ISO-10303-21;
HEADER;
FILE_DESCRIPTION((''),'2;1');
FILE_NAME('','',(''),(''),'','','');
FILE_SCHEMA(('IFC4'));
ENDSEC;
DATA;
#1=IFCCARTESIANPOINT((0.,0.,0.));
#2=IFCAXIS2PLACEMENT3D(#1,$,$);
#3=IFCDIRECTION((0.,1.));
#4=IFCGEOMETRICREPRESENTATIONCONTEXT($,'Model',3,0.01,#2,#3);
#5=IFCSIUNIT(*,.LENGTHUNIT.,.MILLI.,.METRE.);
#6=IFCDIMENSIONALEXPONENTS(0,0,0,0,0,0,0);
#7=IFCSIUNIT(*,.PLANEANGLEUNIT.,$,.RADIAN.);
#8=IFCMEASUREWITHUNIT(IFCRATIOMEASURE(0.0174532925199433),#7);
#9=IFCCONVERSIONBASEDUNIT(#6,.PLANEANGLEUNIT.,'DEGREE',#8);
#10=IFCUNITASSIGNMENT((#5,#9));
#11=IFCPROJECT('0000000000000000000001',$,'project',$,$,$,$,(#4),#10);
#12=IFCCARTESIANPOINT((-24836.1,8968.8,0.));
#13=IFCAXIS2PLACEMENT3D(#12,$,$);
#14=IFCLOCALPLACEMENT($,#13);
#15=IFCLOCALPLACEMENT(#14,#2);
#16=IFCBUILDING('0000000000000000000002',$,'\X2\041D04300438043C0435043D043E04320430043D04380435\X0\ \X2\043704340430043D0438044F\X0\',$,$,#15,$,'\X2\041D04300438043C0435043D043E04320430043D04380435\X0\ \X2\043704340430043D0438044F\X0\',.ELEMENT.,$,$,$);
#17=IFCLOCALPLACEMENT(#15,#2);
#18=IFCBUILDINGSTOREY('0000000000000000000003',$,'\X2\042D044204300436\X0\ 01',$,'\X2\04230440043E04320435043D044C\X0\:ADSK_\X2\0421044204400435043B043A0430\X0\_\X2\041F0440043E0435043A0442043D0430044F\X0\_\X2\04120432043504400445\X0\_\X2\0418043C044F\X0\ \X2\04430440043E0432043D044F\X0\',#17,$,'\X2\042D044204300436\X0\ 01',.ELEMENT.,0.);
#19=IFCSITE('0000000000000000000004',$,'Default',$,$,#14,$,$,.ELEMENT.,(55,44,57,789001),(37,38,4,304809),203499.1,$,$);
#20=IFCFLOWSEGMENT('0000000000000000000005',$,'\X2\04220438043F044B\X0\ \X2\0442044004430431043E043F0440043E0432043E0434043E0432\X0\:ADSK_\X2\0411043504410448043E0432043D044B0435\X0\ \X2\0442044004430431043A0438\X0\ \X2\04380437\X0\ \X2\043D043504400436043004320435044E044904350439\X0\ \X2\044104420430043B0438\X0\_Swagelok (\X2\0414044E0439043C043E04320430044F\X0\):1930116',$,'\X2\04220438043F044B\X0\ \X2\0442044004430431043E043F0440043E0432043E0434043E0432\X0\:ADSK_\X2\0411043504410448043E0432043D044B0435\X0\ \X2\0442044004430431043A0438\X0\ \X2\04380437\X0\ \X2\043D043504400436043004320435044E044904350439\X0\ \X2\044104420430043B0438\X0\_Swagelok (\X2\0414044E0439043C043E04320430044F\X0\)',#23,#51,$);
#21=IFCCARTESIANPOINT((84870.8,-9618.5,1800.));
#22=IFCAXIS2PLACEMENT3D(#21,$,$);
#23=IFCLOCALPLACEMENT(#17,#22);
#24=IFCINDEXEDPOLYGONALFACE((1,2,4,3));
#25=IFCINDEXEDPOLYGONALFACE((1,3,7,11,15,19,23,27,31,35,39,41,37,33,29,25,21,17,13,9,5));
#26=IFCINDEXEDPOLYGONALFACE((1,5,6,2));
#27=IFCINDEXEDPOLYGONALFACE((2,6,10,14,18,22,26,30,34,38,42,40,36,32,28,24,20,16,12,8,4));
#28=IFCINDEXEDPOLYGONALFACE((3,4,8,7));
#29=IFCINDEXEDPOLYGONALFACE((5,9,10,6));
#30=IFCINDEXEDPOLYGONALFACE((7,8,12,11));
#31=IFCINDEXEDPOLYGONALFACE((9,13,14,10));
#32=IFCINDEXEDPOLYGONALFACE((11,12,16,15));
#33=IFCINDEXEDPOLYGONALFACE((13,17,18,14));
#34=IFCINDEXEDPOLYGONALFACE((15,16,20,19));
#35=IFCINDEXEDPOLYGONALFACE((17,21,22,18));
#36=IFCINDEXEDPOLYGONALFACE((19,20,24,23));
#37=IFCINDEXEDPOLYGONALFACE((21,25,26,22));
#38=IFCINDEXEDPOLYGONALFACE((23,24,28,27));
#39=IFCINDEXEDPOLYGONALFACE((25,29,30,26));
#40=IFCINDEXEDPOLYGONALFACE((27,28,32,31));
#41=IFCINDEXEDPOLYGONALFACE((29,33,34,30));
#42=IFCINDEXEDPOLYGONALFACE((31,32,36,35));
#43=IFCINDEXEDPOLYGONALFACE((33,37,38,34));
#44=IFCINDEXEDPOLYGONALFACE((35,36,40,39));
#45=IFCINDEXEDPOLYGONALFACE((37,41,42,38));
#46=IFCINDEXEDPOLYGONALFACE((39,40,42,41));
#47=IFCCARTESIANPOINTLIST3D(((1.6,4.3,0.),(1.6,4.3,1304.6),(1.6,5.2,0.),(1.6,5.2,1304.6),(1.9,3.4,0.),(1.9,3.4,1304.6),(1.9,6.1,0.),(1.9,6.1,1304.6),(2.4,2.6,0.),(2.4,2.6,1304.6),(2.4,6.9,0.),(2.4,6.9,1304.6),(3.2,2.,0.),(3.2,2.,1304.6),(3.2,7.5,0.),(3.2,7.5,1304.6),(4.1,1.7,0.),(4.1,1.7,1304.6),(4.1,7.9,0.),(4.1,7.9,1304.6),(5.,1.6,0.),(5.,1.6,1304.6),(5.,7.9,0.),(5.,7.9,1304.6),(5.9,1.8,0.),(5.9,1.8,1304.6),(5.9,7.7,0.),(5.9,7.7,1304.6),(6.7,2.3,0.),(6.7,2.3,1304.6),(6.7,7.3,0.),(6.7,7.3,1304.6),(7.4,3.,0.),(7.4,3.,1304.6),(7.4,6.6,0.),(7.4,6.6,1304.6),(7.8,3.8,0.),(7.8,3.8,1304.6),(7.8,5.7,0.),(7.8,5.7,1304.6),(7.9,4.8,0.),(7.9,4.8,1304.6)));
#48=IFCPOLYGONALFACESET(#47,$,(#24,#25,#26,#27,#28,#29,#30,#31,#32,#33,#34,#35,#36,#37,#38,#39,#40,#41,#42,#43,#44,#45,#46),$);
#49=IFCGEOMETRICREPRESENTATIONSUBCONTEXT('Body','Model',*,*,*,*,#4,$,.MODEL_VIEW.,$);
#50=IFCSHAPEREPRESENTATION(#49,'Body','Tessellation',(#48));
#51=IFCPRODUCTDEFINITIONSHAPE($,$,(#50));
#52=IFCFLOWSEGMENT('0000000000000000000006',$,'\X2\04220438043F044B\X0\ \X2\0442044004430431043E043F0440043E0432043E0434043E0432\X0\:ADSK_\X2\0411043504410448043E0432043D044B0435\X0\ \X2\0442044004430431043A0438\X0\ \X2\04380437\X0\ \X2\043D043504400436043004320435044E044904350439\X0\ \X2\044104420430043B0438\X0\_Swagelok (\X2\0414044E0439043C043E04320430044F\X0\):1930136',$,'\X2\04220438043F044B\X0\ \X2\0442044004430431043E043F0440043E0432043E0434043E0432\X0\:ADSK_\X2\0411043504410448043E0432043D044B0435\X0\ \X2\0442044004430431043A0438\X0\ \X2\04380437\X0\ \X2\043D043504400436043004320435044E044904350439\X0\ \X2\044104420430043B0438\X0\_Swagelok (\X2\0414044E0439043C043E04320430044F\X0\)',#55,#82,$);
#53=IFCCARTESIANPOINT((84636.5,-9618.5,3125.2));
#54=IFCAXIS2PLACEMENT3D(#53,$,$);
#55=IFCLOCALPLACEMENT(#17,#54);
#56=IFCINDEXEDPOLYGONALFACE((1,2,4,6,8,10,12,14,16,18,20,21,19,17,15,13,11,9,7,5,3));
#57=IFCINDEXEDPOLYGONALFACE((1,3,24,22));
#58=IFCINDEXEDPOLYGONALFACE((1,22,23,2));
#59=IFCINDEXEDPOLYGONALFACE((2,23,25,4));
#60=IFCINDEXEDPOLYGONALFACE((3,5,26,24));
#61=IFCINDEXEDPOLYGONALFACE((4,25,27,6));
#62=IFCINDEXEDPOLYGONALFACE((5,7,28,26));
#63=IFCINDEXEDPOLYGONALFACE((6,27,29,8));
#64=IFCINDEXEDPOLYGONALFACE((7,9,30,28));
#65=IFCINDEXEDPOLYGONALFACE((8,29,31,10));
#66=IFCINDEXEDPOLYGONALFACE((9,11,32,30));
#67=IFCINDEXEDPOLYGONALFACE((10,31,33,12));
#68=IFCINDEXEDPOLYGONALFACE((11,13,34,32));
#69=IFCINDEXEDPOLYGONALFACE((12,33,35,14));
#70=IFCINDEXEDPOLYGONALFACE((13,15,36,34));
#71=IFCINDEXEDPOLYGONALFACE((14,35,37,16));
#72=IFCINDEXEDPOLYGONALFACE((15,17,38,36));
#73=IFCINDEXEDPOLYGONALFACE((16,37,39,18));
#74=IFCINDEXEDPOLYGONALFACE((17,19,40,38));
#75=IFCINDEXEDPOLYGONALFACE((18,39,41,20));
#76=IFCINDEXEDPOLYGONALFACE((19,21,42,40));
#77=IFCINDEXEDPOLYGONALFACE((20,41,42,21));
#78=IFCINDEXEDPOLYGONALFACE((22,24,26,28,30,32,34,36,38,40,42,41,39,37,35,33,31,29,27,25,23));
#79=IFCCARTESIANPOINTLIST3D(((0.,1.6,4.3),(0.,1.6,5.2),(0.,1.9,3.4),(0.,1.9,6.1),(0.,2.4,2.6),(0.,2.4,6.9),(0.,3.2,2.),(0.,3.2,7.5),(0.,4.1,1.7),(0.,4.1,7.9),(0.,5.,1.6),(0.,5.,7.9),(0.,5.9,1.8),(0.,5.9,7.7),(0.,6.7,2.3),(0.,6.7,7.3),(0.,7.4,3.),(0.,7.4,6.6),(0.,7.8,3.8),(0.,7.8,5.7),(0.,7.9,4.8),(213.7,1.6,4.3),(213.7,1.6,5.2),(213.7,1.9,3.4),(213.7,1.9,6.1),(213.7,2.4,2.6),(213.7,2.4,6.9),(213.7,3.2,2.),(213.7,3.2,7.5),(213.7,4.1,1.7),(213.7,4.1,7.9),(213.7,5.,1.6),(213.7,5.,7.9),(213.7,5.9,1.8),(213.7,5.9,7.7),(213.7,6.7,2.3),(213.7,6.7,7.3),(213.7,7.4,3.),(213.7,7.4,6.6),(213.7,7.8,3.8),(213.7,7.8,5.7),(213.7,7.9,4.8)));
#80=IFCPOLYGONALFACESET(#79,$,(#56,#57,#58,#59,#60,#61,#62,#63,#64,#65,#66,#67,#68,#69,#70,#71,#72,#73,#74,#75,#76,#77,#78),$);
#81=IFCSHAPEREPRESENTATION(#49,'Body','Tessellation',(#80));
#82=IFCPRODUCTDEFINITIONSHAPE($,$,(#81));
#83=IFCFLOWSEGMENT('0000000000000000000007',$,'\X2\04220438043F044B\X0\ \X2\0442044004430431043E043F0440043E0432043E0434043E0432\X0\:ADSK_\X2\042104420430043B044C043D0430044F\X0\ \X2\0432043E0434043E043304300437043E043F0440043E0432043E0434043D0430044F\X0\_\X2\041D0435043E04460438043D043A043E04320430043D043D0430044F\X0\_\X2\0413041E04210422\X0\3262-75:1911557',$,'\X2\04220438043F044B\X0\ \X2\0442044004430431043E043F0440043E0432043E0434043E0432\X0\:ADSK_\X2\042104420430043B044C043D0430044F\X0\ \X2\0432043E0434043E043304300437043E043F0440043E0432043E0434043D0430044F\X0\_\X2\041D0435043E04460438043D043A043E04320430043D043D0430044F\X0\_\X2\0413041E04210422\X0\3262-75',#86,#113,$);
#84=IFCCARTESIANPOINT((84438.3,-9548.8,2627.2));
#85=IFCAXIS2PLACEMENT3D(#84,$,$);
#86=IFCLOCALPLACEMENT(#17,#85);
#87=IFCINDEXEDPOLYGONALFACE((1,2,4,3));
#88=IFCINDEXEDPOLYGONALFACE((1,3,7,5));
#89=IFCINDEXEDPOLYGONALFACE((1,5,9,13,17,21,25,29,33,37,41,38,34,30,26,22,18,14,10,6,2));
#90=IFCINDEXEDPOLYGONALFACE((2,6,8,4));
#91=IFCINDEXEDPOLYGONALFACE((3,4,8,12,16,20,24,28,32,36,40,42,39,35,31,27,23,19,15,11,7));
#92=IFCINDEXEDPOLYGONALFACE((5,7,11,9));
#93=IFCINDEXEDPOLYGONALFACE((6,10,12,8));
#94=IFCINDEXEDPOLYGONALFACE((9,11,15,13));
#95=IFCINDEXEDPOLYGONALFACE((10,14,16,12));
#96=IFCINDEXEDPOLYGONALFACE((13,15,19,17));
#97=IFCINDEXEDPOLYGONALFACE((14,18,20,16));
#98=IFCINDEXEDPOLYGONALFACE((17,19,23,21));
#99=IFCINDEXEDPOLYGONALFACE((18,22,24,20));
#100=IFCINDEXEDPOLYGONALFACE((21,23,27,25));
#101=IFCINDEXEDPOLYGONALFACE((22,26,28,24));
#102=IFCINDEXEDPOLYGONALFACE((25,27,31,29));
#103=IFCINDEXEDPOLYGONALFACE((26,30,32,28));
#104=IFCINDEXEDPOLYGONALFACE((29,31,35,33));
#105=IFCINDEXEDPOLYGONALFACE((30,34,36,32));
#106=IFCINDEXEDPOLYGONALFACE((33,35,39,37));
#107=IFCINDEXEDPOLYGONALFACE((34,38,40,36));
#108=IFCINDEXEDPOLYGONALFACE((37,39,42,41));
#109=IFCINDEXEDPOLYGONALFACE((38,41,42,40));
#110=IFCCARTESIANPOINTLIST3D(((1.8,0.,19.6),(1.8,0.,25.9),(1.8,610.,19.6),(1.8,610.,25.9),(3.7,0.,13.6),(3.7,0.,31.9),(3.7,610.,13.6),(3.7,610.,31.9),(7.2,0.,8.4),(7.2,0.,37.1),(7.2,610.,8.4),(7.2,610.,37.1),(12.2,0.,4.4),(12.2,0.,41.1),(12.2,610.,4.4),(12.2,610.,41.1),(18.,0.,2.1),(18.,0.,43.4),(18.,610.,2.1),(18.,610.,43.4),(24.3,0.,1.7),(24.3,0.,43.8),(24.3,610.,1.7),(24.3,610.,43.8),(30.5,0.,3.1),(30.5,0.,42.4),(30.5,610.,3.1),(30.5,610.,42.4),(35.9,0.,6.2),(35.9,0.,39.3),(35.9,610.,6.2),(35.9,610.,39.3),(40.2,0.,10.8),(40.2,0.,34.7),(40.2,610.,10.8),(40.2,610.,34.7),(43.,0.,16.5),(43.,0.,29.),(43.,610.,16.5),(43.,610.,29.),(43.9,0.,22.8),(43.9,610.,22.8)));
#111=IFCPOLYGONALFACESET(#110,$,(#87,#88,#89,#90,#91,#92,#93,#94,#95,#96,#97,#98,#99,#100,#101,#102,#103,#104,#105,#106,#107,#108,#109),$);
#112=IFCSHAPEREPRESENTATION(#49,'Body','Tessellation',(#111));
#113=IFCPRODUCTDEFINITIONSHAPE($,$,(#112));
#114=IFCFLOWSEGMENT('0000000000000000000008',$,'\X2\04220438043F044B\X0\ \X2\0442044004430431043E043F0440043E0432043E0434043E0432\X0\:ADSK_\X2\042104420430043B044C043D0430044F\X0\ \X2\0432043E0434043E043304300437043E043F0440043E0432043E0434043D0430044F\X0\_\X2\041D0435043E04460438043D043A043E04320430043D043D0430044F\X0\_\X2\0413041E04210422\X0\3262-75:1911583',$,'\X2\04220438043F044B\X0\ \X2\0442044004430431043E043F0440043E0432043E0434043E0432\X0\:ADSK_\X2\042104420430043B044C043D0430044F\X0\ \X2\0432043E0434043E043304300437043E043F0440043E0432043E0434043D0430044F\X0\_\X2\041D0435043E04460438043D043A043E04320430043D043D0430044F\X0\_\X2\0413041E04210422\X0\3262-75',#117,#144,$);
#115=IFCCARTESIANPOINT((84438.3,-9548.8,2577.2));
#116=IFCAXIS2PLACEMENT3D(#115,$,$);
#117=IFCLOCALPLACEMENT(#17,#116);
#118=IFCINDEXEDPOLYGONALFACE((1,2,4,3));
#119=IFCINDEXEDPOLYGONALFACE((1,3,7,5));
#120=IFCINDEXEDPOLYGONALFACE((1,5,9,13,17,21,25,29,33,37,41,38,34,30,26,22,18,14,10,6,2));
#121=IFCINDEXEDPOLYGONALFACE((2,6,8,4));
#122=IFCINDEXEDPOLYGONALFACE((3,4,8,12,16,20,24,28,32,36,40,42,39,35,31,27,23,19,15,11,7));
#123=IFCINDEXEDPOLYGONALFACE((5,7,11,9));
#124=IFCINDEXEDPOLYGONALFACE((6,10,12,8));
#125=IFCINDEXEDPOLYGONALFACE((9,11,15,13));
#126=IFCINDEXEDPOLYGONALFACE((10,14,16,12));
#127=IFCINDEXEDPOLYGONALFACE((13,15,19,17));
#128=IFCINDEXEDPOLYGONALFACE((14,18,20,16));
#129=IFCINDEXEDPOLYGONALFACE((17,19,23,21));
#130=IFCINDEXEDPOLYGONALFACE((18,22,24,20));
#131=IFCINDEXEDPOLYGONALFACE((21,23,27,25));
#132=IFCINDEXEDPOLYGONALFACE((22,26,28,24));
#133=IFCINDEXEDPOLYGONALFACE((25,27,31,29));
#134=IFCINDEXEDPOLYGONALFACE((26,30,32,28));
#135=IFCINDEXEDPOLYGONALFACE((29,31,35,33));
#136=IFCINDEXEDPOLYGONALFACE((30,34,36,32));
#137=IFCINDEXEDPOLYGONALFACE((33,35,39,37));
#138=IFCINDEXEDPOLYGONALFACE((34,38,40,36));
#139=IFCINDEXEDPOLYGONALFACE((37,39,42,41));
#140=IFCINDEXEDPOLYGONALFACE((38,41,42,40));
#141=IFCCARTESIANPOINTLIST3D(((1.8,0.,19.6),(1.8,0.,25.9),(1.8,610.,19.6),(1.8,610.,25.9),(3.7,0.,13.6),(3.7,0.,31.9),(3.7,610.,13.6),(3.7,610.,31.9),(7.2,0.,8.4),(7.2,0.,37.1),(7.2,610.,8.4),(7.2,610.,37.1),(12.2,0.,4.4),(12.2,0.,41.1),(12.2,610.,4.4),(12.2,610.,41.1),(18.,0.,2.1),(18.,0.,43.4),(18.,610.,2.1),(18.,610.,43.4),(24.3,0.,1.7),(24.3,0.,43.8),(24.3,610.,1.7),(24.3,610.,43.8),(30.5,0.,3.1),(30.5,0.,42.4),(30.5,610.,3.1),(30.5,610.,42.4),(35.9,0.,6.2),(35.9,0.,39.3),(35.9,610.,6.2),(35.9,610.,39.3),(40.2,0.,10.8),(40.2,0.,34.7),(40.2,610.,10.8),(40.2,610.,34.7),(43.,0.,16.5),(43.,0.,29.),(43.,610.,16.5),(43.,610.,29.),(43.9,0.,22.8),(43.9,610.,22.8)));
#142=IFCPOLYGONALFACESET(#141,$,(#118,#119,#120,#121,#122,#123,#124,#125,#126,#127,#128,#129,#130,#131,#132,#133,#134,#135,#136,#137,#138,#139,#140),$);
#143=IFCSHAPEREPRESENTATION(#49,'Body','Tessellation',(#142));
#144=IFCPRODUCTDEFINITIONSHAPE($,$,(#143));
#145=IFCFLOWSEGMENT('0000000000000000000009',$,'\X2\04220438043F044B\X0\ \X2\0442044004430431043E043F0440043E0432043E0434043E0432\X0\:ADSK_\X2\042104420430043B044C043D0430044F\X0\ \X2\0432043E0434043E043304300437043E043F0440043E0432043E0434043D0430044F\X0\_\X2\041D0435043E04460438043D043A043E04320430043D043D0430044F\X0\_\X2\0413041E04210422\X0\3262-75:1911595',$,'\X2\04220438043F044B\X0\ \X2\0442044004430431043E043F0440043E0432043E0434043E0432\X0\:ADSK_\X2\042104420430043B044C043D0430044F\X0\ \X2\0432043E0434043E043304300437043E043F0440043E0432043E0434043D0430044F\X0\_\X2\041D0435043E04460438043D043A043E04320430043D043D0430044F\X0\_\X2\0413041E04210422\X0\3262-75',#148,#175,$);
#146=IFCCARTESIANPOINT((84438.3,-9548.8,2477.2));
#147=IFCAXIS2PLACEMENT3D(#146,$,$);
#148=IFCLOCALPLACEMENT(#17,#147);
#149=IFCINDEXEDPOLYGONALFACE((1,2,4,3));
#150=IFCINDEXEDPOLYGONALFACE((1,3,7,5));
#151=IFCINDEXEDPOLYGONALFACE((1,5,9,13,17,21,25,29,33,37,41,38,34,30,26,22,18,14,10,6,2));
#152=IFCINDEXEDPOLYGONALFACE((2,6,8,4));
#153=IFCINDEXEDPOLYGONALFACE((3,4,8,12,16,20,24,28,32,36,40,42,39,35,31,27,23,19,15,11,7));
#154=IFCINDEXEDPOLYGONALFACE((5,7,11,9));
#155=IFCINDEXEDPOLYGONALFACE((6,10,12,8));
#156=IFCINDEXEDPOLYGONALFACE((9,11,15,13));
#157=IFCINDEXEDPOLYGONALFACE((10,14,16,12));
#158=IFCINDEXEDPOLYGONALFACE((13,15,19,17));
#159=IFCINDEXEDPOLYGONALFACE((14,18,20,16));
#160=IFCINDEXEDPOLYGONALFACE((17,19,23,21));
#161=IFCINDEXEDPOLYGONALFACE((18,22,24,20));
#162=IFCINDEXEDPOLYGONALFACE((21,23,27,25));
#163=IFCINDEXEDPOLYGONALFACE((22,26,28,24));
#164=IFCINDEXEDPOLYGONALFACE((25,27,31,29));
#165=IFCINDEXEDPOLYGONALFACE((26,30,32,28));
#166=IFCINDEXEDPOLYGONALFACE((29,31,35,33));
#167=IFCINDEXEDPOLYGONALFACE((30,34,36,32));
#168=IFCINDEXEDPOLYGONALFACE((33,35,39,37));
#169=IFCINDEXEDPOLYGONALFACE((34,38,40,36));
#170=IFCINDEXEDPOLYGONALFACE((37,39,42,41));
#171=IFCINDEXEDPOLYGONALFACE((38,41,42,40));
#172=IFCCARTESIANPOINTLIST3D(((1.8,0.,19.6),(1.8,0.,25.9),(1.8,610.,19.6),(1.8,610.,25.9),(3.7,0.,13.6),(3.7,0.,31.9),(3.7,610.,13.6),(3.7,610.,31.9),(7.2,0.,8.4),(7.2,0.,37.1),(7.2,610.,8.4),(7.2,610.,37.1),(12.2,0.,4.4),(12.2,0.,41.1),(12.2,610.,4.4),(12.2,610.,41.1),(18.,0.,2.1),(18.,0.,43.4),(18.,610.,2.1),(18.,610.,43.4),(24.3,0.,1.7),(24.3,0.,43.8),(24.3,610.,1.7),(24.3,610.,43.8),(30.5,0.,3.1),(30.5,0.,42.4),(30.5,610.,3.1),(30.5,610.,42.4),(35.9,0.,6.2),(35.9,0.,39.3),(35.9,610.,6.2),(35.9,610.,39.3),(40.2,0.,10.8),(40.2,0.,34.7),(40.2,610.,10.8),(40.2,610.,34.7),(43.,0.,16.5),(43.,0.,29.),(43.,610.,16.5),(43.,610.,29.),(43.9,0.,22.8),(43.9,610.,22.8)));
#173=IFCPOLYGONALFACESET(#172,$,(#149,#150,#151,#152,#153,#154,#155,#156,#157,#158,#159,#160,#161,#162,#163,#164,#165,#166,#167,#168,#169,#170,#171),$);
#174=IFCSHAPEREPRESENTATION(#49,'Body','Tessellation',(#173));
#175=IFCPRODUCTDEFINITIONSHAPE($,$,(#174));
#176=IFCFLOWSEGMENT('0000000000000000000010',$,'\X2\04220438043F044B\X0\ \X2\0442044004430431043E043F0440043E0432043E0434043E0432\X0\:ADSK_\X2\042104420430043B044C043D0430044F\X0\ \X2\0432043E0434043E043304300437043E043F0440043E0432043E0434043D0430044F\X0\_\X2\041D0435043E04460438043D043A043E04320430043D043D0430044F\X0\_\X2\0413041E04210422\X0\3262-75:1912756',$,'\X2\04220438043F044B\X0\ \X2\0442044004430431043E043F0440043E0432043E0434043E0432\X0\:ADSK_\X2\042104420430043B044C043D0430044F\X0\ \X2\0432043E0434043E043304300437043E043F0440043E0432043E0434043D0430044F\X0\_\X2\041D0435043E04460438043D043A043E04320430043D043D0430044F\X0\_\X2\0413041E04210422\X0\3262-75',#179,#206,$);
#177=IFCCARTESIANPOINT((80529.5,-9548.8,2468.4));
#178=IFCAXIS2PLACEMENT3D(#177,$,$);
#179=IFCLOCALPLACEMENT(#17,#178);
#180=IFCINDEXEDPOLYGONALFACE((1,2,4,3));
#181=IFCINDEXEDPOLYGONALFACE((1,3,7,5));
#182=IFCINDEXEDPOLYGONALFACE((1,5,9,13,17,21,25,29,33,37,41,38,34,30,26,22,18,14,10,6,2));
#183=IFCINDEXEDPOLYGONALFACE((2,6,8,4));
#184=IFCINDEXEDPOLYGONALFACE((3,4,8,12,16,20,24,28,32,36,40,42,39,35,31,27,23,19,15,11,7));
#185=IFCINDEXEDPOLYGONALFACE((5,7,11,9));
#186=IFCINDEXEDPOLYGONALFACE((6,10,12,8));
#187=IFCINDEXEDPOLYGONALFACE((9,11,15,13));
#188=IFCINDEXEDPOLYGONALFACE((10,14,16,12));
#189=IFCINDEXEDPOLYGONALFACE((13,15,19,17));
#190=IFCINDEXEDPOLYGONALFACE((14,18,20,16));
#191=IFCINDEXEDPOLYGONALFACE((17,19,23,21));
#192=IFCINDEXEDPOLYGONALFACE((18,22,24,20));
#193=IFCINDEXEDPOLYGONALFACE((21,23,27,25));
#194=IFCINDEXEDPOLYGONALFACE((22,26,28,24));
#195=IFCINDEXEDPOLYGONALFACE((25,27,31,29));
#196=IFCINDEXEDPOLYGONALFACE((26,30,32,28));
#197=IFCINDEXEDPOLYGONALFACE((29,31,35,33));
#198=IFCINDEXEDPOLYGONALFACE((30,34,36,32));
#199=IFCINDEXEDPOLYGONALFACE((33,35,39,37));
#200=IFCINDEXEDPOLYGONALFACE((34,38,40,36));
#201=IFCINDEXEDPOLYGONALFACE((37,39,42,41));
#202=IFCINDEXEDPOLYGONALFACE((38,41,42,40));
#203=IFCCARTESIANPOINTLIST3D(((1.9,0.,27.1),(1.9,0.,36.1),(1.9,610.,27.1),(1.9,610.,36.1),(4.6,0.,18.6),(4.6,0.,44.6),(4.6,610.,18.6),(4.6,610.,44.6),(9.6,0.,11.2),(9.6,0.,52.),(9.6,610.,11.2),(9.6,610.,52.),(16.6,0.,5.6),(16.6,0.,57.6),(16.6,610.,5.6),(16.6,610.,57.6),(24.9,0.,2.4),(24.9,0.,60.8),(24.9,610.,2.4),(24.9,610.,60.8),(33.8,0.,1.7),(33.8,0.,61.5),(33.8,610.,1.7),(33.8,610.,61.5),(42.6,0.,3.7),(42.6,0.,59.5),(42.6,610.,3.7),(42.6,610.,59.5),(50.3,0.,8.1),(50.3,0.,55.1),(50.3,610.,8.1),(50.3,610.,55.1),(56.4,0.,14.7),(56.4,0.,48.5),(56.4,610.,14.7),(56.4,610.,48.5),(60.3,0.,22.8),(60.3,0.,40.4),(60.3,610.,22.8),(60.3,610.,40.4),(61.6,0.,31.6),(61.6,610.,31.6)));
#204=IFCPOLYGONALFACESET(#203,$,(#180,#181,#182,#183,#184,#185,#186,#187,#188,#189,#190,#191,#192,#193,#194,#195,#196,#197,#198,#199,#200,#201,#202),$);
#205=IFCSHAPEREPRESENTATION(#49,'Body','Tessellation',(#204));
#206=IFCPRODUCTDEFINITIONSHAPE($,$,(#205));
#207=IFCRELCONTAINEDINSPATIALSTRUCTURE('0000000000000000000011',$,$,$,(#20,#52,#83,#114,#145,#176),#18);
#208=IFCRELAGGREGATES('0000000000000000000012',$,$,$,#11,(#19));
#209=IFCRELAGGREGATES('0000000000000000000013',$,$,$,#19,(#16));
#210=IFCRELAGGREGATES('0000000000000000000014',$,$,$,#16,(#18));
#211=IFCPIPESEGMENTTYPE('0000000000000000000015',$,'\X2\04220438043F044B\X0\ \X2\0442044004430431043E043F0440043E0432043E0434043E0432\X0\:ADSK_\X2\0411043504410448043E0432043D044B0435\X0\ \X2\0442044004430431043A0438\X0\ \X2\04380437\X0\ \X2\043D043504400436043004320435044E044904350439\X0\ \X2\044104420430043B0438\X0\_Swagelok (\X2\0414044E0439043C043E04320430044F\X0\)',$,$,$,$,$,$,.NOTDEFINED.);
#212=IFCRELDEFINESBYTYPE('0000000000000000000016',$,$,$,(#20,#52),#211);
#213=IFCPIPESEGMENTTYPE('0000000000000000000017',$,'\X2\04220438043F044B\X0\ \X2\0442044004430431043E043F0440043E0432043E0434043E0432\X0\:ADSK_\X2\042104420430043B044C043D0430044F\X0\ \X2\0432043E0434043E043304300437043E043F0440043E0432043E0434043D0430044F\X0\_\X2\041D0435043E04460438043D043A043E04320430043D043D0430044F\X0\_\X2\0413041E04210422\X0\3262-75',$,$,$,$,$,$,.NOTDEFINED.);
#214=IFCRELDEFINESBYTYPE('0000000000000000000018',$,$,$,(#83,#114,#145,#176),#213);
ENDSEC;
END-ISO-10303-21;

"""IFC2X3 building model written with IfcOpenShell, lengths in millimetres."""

from ifc_helpers import new_model, entity, si_unit, converted_unit, direction, frame, origin, origin_2d_with_axis, place, context, subcontext, project, spatial, circle, extrude, type_object, element, save


model = new_model("IFC2X3")

# Units and contexts
model_context = context("Model", 3, precision=0.01, world=origin(), true_north=direction((0.0, 1.0)))
body_context = subcontext(model_context, "Body", "Model", "MODEL_VIEW")
ifc_project = project(units=[si_unit("LENGTHUNIT", "METRE", prefix="MILLI"), converted_unit("PLANEANGLEUNIT", "DEGREE", entity("IfcRatioMeasure", 0.0174532925199433), si_unit("PLANEANGLEUNIT", "RADIAN"), dimensions=[0, 0, 0, 0, 0, 0, 0])], contexts=[model_context])

# Site, building, storey
site_placement = place(None, frame((-24836.1, 8968.8, 0.0)))
site = spatial("IfcSite", under=ifc_project, at=site_placement, Name="Default", CompositionType="ELEMENT", RefLatitude=(55, 44, 57, 789001), RefLongitude=(37, 38, 4, 304809), RefElevation=203499.1)
building_placement = place(site_placement, origin())
building = spatial("IfcBuilding", under=site, at=building_placement, Name="Наименование здания", LongName="Наименование здания", CompositionType="ELEMENT")
storey_placement = place(building_placement, origin())
storey = spatial("IfcBuildingStorey", under=building, at=storey_placement, Name="Этаж 01", ObjectType="Уровень:ADSK_Стрелка_Проектная_Вверх_Имя уровня", LongName="Этаж 01", CompositionType="ELEMENT", Elevation=0.0)

# Flow segments
pipe_segment_type_1 = type_object("IfcPipeSegmentType", Name="Типы трубопроводов:ADSK_Бесшовные трубки из нержавеющей стали_Swagelok (Дюймовая)", PredefinedType="NOTDEFINED")
flow_segment_1_placement = place(storey_placement, frame((84870.8, -9618.5, 1800.0)))
element("IfcFlowSegment", 1, at=flow_segment_1_placement, inside=storey, type_object=pipe_segment_type_1, Name="Типы трубопроводов:ADSK_Бесшовные трубки из нержавеющей стали_Swagelok (Дюймовая):1930116", ObjectType="Типы трубопроводов:ADSK_Бесшовные трубки из нержавеющей стали_Swagelok (Дюймовая)", context=body_context, shape_type="SweptSolid", body=[
    extrude(circle(Radius=3.2, at=origin_2d_with_axis()), frame((4.8, 4.8, 0.0)), (0.0, 0.0, 1.0), 1304.6),
])
flow_segment_2_placement = place(storey_placement, frame((84636.5, -9618.5, 3125.2)))
element("IfcFlowSegment", 2, at=flow_segment_2_placement, inside=storey, type_object=pipe_segment_type_1, Name="Типы трубопроводов:ADSK_Бесшовные трубки из нержавеющей стали_Swagelok (Дюймовая):1930136", ObjectType="Типы трубопроводов:ADSK_Бесшовные трубки из нержавеющей стали_Swagelok (Дюймовая)", context=body_context, shape_type="SweptSolid", body=[
    extrude(circle(Radius=3.2, at=origin_2d_with_axis()), frame((0.0, 4.8, 4.8), z_axis=(1.0, 0.0, 0.0), x_axis=(0.0, 1.0, 0.0)), (0.0, 0.0, 1.0), 213.7),
])
pipe_segment_type_2 = type_object("IfcPipeSegmentType", Name="Типы трубопроводов:ADSK_Стальная водогазопроводная_Неоцинкованная_ГОСТ3262-75", PredefinedType="NOTDEFINED")
for number, where, name in (
    (3, (84438.3, -9548.8, 2627.2), "Типы трубопроводов:ADSK_Стальная водогазопроводная_Неоцинкованная_ГОСТ3262-75:1911557"),
    (4, (84438.3, -9548.8, 2577.2), "Типы трубопроводов:ADSK_Стальная водогазопроводная_Неоцинкованная_ГОСТ3262-75:1911583"),
    (5, (84438.3, -9548.8, 2477.2), "Типы трубопроводов:ADSK_Стальная водогазопроводная_Неоцинкованная_ГОСТ3262-75:1911595"),
):
    element("IfcFlowSegment", number, at=place(storey_placement, frame(where)), inside=storey, type_object=pipe_segment_type_2, Name=name, ObjectType="Типы трубопроводов:ADSK_Стальная водогазопроводная_Неоцинкованная_ГОСТ3262-75", context=body_context, shape_type="SweptSolid", body=[
        extrude(circle(Radius=21.1, at=origin_2d_with_axis()), frame((22.8, 0.0, 22.8), z_axis=(0.0, 1.0, 0.0), x_axis=(1.0, 0.0, 0.0)), (0.0, 0.0, 1.0), 610.0),
    ])
flow_segment_3_placement = place(storey_placement, frame((80529.5, -9548.8, 2468.4)))
element("IfcFlowSegment", 6, at=flow_segment_3_placement, inside=storey, type_object=pipe_segment_type_2, Name="Типы трубопроводов:ADSK_Стальная водогазопроводная_Неоцинкованная_ГОСТ3262-75:1912756", ObjectType="Типы трубопроводов:ADSK_Стальная водогазопроводная_Неоцинкованная_ГОСТ3262-75", context=body_context, shape_type="SweptSolid", body=[
    extrude(circle(Radius=30.0, at=origin_2d_with_axis()), frame((31.6, 0.0, 31.6), z_axis=(0.0, 1.0, 0.0), x_axis=(1.0, 0.0, 0.0)), (0.0, 0.0, 1.0), 610.0),
])

save(model, "model.ifc")
